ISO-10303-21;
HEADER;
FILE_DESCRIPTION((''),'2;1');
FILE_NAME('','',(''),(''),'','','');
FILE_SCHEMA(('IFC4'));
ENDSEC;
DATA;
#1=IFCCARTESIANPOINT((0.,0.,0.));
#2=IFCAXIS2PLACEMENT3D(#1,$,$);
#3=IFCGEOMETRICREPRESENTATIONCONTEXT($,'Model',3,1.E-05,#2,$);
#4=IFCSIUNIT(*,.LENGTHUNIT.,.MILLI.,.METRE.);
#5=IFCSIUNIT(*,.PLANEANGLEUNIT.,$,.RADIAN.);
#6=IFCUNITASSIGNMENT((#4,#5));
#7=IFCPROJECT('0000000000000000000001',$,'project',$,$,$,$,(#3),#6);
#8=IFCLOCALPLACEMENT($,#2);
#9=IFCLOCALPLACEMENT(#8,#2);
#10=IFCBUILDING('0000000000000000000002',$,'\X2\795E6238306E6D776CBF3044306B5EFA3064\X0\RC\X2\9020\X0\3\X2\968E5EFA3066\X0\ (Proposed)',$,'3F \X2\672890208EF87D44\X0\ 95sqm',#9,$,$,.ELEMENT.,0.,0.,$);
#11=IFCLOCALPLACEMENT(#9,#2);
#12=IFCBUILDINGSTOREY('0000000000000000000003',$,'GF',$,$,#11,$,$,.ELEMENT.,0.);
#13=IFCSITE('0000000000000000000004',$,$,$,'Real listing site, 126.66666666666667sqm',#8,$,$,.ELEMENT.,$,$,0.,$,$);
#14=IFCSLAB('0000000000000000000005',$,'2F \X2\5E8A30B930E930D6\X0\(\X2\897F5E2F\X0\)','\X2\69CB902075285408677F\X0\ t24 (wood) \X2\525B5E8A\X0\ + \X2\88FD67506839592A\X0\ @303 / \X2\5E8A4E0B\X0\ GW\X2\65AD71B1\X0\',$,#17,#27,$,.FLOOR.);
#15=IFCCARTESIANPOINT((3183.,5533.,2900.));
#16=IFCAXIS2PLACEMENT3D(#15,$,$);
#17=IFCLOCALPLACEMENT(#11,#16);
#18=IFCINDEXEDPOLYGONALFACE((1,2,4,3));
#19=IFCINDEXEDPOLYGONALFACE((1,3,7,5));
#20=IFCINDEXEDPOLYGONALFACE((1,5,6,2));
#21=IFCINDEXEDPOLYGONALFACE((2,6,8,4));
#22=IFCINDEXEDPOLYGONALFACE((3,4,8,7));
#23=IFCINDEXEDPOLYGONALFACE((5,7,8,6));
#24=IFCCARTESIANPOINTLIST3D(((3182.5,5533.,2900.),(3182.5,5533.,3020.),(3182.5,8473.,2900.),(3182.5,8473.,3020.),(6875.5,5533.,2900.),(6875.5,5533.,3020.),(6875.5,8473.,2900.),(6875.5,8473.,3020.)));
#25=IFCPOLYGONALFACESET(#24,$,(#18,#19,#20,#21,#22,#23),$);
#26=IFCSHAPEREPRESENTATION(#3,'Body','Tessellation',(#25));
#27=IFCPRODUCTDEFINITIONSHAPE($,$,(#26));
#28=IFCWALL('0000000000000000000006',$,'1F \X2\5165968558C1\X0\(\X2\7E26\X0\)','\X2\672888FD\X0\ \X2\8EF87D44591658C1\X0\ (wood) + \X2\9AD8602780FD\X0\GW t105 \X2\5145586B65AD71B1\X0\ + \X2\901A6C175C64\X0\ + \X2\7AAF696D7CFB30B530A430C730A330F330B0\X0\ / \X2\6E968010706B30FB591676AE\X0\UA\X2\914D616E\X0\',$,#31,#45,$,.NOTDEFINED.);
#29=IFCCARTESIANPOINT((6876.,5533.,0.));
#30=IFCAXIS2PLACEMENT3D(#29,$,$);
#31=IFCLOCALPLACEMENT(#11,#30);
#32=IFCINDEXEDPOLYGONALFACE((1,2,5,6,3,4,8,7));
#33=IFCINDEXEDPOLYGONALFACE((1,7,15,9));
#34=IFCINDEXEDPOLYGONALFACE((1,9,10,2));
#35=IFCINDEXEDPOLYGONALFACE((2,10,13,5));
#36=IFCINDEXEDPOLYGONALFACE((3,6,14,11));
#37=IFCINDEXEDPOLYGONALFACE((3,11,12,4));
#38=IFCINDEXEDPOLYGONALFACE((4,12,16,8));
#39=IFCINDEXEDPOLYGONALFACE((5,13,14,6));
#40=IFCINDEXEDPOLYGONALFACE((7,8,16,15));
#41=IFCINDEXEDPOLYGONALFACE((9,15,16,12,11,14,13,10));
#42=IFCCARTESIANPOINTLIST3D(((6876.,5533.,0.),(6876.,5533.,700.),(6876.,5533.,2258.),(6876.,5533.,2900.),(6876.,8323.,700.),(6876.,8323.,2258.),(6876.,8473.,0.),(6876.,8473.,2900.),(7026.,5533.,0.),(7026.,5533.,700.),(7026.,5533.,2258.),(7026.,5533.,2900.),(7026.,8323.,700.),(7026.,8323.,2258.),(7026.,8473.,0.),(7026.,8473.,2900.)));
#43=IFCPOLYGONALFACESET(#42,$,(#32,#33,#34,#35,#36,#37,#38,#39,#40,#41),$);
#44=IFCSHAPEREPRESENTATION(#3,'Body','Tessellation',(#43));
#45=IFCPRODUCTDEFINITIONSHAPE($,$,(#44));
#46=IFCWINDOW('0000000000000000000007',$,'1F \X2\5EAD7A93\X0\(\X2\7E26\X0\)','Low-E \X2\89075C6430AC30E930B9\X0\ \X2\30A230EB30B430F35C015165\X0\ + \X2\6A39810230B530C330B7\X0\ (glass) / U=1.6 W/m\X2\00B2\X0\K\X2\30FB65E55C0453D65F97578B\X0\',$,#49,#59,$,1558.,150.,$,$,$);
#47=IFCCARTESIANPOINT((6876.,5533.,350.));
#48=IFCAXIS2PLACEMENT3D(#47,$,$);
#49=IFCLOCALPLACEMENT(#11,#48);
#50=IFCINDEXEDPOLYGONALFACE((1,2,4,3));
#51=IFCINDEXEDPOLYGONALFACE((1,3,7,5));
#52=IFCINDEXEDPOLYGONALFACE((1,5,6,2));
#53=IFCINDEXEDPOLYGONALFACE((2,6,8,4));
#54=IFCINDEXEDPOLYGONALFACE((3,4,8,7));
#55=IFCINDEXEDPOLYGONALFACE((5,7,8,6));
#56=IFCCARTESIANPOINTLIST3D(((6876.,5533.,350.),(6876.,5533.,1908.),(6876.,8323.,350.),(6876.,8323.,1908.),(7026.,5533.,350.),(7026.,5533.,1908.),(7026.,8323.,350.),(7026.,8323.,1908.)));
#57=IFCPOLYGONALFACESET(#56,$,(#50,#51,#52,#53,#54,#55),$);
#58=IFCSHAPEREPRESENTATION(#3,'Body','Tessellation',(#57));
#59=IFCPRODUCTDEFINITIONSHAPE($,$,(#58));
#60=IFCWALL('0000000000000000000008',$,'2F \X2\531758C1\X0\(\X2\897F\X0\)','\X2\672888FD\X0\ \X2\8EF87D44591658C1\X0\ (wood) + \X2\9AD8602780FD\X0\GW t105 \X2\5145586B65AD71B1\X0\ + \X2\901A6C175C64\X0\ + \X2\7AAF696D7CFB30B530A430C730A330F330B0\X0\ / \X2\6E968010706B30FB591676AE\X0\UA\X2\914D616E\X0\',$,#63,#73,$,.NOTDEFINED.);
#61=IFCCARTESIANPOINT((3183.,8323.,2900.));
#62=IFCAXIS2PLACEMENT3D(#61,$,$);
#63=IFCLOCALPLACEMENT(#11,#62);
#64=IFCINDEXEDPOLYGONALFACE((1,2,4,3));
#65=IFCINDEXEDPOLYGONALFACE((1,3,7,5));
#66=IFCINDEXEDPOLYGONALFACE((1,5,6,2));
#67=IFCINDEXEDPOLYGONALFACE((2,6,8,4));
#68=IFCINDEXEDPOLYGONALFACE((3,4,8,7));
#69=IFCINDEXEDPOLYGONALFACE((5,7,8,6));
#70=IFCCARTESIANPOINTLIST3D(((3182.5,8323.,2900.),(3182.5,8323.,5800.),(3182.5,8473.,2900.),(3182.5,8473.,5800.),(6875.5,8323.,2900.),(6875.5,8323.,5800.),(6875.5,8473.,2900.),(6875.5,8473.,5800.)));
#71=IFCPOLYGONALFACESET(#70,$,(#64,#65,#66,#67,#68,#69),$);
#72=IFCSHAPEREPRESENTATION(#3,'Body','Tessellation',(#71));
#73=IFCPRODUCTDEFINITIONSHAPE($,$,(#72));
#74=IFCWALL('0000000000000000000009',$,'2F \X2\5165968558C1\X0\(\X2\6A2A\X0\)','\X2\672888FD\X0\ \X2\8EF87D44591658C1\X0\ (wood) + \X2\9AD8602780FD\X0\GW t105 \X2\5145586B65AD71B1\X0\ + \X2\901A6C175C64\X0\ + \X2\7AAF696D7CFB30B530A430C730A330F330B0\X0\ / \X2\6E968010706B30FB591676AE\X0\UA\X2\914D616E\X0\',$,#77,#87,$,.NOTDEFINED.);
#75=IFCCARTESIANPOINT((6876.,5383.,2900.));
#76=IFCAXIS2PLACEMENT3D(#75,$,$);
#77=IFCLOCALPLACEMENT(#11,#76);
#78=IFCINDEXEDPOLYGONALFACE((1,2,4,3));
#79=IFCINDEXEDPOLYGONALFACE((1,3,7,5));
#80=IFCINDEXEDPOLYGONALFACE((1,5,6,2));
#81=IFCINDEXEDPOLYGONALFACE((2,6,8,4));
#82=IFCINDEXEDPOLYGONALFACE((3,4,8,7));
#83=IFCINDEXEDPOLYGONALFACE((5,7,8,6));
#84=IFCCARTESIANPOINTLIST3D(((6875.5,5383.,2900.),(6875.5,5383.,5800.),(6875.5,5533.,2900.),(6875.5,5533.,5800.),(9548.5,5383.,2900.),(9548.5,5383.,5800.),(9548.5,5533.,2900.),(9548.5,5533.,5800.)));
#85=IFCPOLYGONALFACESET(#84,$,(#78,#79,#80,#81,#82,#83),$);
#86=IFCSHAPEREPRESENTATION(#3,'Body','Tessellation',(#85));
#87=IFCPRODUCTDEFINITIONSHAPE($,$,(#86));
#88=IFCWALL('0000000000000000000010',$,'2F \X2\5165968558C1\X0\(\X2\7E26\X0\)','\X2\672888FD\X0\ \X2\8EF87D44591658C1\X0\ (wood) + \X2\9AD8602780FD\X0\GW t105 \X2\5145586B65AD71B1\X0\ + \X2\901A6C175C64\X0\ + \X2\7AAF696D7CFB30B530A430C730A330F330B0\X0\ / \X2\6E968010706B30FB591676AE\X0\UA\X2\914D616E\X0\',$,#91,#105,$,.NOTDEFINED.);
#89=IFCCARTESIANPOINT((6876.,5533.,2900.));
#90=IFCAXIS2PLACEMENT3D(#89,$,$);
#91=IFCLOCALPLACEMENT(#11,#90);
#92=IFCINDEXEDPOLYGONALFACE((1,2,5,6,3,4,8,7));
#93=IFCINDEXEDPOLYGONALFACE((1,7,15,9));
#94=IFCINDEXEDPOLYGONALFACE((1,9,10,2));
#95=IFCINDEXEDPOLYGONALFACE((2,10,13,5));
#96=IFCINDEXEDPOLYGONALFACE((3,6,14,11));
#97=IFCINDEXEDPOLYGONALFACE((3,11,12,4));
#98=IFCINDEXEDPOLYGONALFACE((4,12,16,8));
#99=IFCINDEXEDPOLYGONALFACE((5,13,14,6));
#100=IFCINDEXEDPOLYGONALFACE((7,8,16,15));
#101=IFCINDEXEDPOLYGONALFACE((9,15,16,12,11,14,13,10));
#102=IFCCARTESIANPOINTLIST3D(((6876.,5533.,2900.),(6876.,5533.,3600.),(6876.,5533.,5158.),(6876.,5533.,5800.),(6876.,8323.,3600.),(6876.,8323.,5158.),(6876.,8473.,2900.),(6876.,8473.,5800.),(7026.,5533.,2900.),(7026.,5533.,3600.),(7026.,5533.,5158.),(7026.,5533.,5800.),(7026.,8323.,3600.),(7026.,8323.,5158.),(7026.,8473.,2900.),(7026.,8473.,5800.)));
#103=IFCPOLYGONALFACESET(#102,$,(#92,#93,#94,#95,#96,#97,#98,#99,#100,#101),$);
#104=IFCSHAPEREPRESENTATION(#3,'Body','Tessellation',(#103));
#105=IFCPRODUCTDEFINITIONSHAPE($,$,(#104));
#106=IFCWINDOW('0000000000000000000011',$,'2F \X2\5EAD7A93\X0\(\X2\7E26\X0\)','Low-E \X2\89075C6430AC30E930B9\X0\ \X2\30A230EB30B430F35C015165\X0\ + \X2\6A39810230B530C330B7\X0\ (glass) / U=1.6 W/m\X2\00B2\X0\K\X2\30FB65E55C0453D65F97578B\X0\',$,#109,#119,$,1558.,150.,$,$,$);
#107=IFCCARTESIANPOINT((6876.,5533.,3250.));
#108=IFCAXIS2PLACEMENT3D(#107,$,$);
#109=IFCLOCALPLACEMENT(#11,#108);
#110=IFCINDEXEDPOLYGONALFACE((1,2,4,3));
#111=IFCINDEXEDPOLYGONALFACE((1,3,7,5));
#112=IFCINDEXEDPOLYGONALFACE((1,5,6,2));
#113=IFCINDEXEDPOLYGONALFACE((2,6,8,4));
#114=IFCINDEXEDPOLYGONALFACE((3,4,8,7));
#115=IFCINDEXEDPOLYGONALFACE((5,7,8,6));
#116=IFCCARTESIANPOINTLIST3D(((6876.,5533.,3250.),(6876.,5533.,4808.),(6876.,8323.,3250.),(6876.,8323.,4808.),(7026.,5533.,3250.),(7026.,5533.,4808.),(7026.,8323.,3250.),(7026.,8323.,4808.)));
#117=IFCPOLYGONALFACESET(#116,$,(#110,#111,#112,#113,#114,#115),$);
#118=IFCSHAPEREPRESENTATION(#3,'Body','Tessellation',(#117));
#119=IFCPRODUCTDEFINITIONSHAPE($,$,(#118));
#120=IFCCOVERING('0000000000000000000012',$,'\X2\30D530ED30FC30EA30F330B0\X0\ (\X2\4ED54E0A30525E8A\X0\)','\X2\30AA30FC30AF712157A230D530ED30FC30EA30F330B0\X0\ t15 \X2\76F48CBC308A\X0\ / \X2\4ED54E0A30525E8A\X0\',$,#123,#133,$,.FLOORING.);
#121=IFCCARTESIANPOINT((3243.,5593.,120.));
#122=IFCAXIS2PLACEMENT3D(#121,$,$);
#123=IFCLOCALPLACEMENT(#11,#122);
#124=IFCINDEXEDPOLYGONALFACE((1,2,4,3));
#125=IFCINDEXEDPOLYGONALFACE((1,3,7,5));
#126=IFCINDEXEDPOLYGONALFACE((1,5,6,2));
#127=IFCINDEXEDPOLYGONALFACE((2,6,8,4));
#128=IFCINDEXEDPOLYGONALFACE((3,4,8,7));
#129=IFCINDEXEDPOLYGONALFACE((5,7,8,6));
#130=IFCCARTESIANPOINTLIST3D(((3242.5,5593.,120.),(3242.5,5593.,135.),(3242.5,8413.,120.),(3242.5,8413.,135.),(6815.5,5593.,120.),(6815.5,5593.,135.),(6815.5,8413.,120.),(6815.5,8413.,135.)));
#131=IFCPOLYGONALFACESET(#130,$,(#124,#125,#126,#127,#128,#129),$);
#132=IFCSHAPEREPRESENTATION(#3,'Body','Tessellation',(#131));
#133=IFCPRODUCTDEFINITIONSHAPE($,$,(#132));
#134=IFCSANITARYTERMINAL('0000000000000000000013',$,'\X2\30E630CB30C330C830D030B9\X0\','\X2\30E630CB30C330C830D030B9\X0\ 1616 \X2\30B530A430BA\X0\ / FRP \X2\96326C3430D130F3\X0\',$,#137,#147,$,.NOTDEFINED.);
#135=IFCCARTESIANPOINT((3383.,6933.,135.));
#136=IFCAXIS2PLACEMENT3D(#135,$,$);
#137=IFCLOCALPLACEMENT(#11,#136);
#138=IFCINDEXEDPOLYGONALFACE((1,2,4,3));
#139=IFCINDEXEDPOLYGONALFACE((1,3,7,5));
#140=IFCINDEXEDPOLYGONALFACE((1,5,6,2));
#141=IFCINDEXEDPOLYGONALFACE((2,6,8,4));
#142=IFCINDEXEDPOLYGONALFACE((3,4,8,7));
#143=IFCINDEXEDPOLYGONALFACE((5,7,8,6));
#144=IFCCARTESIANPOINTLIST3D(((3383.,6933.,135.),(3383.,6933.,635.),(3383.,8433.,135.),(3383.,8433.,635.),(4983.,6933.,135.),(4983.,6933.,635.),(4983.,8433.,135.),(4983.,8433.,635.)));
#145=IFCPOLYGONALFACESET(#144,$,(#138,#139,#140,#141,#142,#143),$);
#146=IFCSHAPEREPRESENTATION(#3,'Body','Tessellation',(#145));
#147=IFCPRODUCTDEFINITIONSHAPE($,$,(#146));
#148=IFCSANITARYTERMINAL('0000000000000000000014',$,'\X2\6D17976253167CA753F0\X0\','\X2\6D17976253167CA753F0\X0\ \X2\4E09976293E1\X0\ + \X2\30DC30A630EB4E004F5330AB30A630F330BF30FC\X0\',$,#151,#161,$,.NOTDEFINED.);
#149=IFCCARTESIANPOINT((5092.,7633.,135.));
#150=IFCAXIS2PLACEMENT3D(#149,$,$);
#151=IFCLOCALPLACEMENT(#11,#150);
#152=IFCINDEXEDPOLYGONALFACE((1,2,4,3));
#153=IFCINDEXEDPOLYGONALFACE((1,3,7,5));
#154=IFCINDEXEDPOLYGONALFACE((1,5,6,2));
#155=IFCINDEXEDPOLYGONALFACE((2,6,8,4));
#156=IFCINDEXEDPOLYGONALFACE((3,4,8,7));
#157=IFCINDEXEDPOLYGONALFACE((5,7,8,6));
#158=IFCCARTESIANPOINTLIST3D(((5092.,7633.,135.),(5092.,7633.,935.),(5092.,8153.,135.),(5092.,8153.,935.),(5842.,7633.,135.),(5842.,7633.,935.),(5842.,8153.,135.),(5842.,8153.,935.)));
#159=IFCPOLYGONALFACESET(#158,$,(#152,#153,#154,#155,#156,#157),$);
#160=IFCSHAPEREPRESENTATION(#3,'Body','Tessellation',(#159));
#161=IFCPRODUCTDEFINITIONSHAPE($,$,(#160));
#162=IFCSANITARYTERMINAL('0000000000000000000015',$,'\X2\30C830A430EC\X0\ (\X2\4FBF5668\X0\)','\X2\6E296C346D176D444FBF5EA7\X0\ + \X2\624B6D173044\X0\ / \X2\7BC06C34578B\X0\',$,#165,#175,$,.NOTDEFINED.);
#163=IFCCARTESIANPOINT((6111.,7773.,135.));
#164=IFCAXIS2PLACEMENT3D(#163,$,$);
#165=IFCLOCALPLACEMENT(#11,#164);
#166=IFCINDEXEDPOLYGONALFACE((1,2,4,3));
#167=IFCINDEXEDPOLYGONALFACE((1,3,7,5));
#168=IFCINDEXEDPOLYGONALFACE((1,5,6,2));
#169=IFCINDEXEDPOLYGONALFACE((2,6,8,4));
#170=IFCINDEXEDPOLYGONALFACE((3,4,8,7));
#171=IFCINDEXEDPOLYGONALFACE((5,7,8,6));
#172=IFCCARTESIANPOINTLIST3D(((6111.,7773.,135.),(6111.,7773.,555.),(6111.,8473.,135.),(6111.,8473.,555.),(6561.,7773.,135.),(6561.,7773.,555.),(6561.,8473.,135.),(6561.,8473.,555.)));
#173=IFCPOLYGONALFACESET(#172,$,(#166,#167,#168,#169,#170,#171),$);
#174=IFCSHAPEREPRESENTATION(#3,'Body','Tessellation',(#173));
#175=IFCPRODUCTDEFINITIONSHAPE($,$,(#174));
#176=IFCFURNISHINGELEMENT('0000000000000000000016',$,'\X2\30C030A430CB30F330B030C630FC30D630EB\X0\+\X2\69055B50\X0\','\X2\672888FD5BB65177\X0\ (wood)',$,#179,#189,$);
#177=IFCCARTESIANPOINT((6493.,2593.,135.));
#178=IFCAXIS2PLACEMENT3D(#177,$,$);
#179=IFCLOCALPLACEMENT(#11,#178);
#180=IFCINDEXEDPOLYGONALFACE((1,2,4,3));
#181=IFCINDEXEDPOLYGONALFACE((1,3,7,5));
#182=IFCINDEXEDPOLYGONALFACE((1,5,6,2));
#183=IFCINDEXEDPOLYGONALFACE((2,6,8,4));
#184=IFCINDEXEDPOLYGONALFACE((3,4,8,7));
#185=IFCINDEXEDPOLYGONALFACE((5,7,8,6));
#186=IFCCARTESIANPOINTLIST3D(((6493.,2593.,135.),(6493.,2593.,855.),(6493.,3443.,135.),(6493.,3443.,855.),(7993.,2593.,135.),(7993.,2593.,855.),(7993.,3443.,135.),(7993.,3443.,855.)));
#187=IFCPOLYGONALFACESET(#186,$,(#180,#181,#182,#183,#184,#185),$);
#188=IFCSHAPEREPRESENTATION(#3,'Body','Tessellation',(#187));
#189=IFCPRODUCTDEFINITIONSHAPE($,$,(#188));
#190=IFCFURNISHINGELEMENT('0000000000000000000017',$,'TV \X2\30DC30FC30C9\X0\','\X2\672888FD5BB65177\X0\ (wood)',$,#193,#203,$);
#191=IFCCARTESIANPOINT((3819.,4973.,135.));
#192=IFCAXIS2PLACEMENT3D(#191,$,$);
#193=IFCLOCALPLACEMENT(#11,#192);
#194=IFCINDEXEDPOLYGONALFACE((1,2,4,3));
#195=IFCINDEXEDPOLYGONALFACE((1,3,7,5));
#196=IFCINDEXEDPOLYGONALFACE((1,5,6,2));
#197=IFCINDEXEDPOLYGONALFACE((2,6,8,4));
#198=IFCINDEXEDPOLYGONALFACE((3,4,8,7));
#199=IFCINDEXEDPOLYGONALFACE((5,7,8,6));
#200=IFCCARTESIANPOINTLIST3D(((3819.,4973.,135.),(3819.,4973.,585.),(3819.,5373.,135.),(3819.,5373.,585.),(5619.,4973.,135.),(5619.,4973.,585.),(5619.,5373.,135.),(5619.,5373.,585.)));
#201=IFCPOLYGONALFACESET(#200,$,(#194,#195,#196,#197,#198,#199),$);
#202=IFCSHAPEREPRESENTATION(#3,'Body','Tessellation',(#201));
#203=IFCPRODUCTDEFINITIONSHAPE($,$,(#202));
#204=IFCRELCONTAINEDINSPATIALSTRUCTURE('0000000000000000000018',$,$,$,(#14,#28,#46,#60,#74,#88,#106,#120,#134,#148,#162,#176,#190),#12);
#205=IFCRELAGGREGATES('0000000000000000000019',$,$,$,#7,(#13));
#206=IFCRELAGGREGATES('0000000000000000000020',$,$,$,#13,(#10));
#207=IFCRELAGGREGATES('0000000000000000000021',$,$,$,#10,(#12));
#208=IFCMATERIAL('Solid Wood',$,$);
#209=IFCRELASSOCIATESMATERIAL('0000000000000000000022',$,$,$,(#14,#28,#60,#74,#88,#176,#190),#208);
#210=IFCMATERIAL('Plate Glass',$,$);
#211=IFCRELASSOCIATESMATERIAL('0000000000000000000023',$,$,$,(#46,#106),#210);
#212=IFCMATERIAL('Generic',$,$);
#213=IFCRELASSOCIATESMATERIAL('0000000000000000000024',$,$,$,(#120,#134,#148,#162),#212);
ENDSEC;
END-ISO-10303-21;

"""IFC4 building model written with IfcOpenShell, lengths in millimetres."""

from ifc_helpers import new_model, si_unit, frame, frame_2d, origin, place, context, project, spatial, rectangle, extrude, material, element, fill, save


model = new_model("IFC4")

# Units and contexts
model_context = context("Model", 3, precision=1e-05, world=origin())
ifc_project = project(units=[si_unit("LENGTHUNIT", "METRE", prefix="MILLI"), si_unit("PLANEANGLEUNIT", "RADIAN")], contexts=[model_context])

# Site, building, storey
site_placement = place(None, origin())
site = spatial("IfcSite", under=ifc_project, at=site_placement, ObjectType="Real listing site, 126.66666666666667sqm", CompositionType="ELEMENT", RefElevation=0.0)
building_placement = place(site_placement, origin())
building = spatial("IfcBuilding", under=site, at=building_placement, Name="神戸の海沿いに建つRC造3階建て (Proposed)", ObjectType="3F 木造軸組 95sqm", CompositionType="ELEMENT", ElevationOfRefHeight=0.0, ElevationOfTerrain=0.0)
storey_placement = place(building_placement, origin())
storey = spatial("IfcBuildingStorey", under=building, at=storey_placement, Name="GF", CompositionType="ELEMENT", Elevation=0.0)

# Slab
ifc_material_1 = material(Name="Solid Wood")
slab_1_placement = place(storey_placement, frame((3183.0, 5533.0, 2900.0)))
element("IfcSlab", 1, at=slab_1_placement, inside=storey, material=ifc_material_1, Name="2F 床スラブ(西帯)", Description="構造用合板 t24 (wood) 剛床 + 製材根太 @303 / 床下 GW断熱", PredefinedType="FLOOR", context=model_context, shape_type="SweptSolid", body=[
    extrude(rectangle(XDim=3693.0, YDim=2940.0, at=frame_2d((1846.0, 1470.0))), frame((3183.0, 5533.0, 2900.0)), (0.0, 0.0, 1.0), 120.0),
])

# Wall, opening, window
wall_1_placement = place(storey_placement, frame((6876.0, 5533.0, 0.0)))
wall_1 = element("IfcWall", 2, at=wall_1_placement, inside=storey, material=ifc_material_1, Name="1F 入隅壁(縦)", Description="木製 軸組外壁 (wood) + 高性能GW t105 充填断熱 + 通気層 + 窯業系サイディング / 準耐火・外皮UA配慮", PredefinedType="NOTDEFINED", context=model_context, shape_type="SweptSolid", body=[
    extrude(rectangle(XDim=150.0, YDim=2940.0, at=frame_2d((75.0, 1470.0))), frame((6876.0, 5533.0, 0.0)), (0.0, 0.0, 1.0), 2900.0),
])
opening_1_placement = place(storey_placement, frame((6876.0, 5533.0, 350.0)))
opening_1 = element("IfcOpeningElement", 3, at=opening_1_placement, cuts=wall_1, PredefinedType="NOTDEFINED", context=model_context, shape_type="SweptSolid", body=[
    extrude(rectangle(XDim=150.0, YDim=2790.0, at=frame_2d((75.0, 1395.0))), frame((6876.0, 5533.0, 350.0)), (0.0, 0.0, 1.0), 1558.0),
])
ifc_material_2 = material(Name="Plate Glass")
window_1_placement = place(storey_placement, frame((6876.0, 5533.0, 350.0)))
window_1 = element("IfcWindow", 4, at=window_1_placement, inside=storey, material=ifc_material_2, Name="1F 庭窓(縦)", Description="Low-E 複層ガラス アルゴン封入 + 樹脂サッシ (glass) / U=1.6 W/m²K・日射取得型", OverallHeight=1558.0, OverallWidth=150.0, context=model_context, shape_type="SweptSolid", body=[
    extrude(rectangle(XDim=150.0, YDim=2790.0, at=frame_2d((75.0, 1395.0))), frame((6876.0, 5533.0, 350.0)), (0.0, 0.0, 1.0), 1558.0),
])
fill(opening_1, window_1)

# Walls
wall_2_placement = place(storey_placement, frame((3183.0, 8323.0, 2900.0)))
element("IfcWall", 5, at=wall_2_placement, inside=storey, material=ifc_material_1, Name="2F 北壁(西)", Description="木製 軸組外壁 (wood) + 高性能GW t105 充填断熱 + 通気層 + 窯業系サイディング / 準耐火・外皮UA配慮", PredefinedType="NOTDEFINED", context=model_context, shape_type="SweptSolid", body=[
    extrude(rectangle(XDim=3693.0, YDim=150.0, at=frame_2d((1846.0, 75.0))), frame((3183.0, 8323.0, 2900.0)), (0.0, 0.0, 1.0), 2900.0),
])
wall_3_placement = place(storey_placement, frame((6876.0, 5383.0, 2900.0)))
element("IfcWall", 6, at=wall_3_placement, inside=storey, material=ifc_material_1, Name="2F 入隅壁(横)", Description="木製 軸組外壁 (wood) + 高性能GW t105 充填断熱 + 通気層 + 窯業系サイディング / 準耐火・外皮UA配慮", PredefinedType="NOTDEFINED", context=model_context, shape_type="SweptSolid", body=[
    extrude(rectangle(XDim=2673.0, YDim=150.0, at=frame_2d((1336.0, 75.0))), frame((6876.0, 5383.0, 2900.0)), (0.0, 0.0, 1.0), 2900.0),
])

# Wall, opening, window
wall_4_placement = place(storey_placement, frame((6876.0, 5533.0, 2900.0)))
wall_4 = element("IfcWall", 7, at=wall_4_placement, inside=storey, material=ifc_material_1, Name="2F 入隅壁(縦)", Description="木製 軸組外壁 (wood) + 高性能GW t105 充填断熱 + 通気層 + 窯業系サイディング / 準耐火・外皮UA配慮", PredefinedType="NOTDEFINED", context=model_context, shape_type="SweptSolid", body=[
    extrude(rectangle(XDim=150.0, YDim=2940.0, at=frame_2d((75.0, 1470.0))), frame((6876.0, 5533.0, 2900.0)), (0.0, 0.0, 1.0), 2900.0),
])
opening_2_placement = place(storey_placement, frame((6876.0, 5533.0, 3250.0)))
opening_2 = element("IfcOpeningElement", 8, at=opening_2_placement, cuts=wall_4, PredefinedType="NOTDEFINED", context=model_context, shape_type="SweptSolid", body=[
    extrude(rectangle(XDim=150.0, YDim=2790.0, at=frame_2d((75.0, 1395.0))), frame((6876.0, 5533.0, 3250.0)), (0.0, 0.0, 1.0), 1558.0),
])
window_2_placement = place(storey_placement, frame((6876.0, 5533.0, 3250.0)))
window_2 = element("IfcWindow", 9, at=window_2_placement, inside=storey, material=ifc_material_2, Name="2F 庭窓(縦)", Description="Low-E 複層ガラス アルゴン封入 + 樹脂サッシ (glass) / U=1.6 W/m²K・日射取得型", OverallHeight=1558.0, OverallWidth=150.0, context=model_context, shape_type="SweptSolid", body=[
    extrude(rectangle(XDim=150.0, YDim=2790.0, at=frame_2d((75.0, 1395.0))), frame((6876.0, 5533.0, 3250.0)), (0.0, 0.0, 1.0), 1558.0),
])
fill(opening_2, window_2)

# Covering
ifc_material_3 = material(Name="Generic")
covering_placement = place(storey_placement, frame((3243.0, 5593.0, 120.0)))
element("IfcCovering", 10, at=covering_placement, inside=storey, material=ifc_material_3, Name="フローリング (仕上げ床)", Description="オーク無垢フローリング t15 直貼り / 仕上げ床", PredefinedType="FLOORING", context=model_context, shape_type="SweptSolid", body=[
    extrude(rectangle(XDim=3573.0, YDim=2820.0, at=frame_2d((1786.0, 1410.0))), frame((3243.0, 5593.0, 120.0)), (0.0, 0.0, 1.0), 15.0),
])

# Sanitary terminals
sanitary_terminal_1_placement = place(storey_placement, frame((3383.0, 6933.0, 135.0)))
element("IfcSanitaryTerminal", 11, at=sanitary_terminal_1_placement, inside=storey, material=ifc_material_3, Name="ユニットバス", Description="ユニットバス 1616 サイズ / FRP 防水パン", PredefinedType="NOTDEFINED", context=model_context, shape_type="SweptSolid", body=[
    extrude(rectangle(XDim=1600.0, YDim=1500.0, at=frame_2d((800.0, 750.0))), frame((3383.0, 6933.0, 135.0)), (0.0, 0.0, 1.0), 500.0),
])
sanitary_terminal_2_placement = place(storey_placement, frame((5092.0, 7633.0, 135.0)))
element("IfcSanitaryTerminal", 12, at=sanitary_terminal_2_placement, inside=storey, material=ifc_material_3, Name="洗面化粧台", Description="洗面化粧台 三面鏡 + ボウル一体カウンター", PredefinedType="NOTDEFINED", context=model_context, shape_type="SweptSolid", body=[
    extrude(rectangle(XDim=750.0, YDim=520.0, at=frame_2d((375.0, 260.0))), frame((5092.0, 7633.0, 135.0)), (0.0, 0.0, 1.0), 800.0),
])
sanitary_terminal_3_placement = place(storey_placement, frame((6111.0, 7773.0, 135.0)))
element("IfcSanitaryTerminal", 13, at=sanitary_terminal_3_placement, inside=storey, material=ifc_material_3, Name="トイレ (便器)", Description="温水洗浄便座 + 手洗い / 節水型", PredefinedType="NOTDEFINED", context=model_context, shape_type="SweptSolid", body=[
    extrude(rectangle(XDim=450.0, YDim=700.0, at=frame_2d((225.0, 350.0))), frame((6111.0, 7773.0, 135.0)), (0.0, 0.0, 1.0), 420.0),
])

# Furnishing elements
furnishing_1_placement = place(storey_placement, frame((6493.0, 2593.0, 135.0)))
element("IfcFurnishingElement", 14, at=furnishing_1_placement, inside=storey, material=ifc_material_1, Name="ダイニングテーブル+椅子", Description="木製家具 (wood)", context=model_context, shape_type="SweptSolid", body=[
    extrude(rectangle(XDim=1500.0, YDim=850.0, at=frame_2d((750.0, 425.0))), frame((6493.0, 2593.0, 135.0)), (0.0, 0.0, 1.0), 720.0),
])
furnishing_2_placement = place(storey_placement, frame((3819.0, 4973.0, 135.0)))
element("IfcFurnishingElement", 15, at=furnishing_2_placement, inside=storey, material=ifc_material_1, Name="TV ボード", Description="木製家具 (wood)", context=model_context, shape_type="SweptSolid", body=[
    extrude(rectangle(XDim=1800.0, YDim=400.0, at=frame_2d((900.0, 200.0))), frame((3819.0, 4973.0, 135.0)), (0.0, 0.0, 1.0), 450.0),
])

save(model, "model.ifc")
